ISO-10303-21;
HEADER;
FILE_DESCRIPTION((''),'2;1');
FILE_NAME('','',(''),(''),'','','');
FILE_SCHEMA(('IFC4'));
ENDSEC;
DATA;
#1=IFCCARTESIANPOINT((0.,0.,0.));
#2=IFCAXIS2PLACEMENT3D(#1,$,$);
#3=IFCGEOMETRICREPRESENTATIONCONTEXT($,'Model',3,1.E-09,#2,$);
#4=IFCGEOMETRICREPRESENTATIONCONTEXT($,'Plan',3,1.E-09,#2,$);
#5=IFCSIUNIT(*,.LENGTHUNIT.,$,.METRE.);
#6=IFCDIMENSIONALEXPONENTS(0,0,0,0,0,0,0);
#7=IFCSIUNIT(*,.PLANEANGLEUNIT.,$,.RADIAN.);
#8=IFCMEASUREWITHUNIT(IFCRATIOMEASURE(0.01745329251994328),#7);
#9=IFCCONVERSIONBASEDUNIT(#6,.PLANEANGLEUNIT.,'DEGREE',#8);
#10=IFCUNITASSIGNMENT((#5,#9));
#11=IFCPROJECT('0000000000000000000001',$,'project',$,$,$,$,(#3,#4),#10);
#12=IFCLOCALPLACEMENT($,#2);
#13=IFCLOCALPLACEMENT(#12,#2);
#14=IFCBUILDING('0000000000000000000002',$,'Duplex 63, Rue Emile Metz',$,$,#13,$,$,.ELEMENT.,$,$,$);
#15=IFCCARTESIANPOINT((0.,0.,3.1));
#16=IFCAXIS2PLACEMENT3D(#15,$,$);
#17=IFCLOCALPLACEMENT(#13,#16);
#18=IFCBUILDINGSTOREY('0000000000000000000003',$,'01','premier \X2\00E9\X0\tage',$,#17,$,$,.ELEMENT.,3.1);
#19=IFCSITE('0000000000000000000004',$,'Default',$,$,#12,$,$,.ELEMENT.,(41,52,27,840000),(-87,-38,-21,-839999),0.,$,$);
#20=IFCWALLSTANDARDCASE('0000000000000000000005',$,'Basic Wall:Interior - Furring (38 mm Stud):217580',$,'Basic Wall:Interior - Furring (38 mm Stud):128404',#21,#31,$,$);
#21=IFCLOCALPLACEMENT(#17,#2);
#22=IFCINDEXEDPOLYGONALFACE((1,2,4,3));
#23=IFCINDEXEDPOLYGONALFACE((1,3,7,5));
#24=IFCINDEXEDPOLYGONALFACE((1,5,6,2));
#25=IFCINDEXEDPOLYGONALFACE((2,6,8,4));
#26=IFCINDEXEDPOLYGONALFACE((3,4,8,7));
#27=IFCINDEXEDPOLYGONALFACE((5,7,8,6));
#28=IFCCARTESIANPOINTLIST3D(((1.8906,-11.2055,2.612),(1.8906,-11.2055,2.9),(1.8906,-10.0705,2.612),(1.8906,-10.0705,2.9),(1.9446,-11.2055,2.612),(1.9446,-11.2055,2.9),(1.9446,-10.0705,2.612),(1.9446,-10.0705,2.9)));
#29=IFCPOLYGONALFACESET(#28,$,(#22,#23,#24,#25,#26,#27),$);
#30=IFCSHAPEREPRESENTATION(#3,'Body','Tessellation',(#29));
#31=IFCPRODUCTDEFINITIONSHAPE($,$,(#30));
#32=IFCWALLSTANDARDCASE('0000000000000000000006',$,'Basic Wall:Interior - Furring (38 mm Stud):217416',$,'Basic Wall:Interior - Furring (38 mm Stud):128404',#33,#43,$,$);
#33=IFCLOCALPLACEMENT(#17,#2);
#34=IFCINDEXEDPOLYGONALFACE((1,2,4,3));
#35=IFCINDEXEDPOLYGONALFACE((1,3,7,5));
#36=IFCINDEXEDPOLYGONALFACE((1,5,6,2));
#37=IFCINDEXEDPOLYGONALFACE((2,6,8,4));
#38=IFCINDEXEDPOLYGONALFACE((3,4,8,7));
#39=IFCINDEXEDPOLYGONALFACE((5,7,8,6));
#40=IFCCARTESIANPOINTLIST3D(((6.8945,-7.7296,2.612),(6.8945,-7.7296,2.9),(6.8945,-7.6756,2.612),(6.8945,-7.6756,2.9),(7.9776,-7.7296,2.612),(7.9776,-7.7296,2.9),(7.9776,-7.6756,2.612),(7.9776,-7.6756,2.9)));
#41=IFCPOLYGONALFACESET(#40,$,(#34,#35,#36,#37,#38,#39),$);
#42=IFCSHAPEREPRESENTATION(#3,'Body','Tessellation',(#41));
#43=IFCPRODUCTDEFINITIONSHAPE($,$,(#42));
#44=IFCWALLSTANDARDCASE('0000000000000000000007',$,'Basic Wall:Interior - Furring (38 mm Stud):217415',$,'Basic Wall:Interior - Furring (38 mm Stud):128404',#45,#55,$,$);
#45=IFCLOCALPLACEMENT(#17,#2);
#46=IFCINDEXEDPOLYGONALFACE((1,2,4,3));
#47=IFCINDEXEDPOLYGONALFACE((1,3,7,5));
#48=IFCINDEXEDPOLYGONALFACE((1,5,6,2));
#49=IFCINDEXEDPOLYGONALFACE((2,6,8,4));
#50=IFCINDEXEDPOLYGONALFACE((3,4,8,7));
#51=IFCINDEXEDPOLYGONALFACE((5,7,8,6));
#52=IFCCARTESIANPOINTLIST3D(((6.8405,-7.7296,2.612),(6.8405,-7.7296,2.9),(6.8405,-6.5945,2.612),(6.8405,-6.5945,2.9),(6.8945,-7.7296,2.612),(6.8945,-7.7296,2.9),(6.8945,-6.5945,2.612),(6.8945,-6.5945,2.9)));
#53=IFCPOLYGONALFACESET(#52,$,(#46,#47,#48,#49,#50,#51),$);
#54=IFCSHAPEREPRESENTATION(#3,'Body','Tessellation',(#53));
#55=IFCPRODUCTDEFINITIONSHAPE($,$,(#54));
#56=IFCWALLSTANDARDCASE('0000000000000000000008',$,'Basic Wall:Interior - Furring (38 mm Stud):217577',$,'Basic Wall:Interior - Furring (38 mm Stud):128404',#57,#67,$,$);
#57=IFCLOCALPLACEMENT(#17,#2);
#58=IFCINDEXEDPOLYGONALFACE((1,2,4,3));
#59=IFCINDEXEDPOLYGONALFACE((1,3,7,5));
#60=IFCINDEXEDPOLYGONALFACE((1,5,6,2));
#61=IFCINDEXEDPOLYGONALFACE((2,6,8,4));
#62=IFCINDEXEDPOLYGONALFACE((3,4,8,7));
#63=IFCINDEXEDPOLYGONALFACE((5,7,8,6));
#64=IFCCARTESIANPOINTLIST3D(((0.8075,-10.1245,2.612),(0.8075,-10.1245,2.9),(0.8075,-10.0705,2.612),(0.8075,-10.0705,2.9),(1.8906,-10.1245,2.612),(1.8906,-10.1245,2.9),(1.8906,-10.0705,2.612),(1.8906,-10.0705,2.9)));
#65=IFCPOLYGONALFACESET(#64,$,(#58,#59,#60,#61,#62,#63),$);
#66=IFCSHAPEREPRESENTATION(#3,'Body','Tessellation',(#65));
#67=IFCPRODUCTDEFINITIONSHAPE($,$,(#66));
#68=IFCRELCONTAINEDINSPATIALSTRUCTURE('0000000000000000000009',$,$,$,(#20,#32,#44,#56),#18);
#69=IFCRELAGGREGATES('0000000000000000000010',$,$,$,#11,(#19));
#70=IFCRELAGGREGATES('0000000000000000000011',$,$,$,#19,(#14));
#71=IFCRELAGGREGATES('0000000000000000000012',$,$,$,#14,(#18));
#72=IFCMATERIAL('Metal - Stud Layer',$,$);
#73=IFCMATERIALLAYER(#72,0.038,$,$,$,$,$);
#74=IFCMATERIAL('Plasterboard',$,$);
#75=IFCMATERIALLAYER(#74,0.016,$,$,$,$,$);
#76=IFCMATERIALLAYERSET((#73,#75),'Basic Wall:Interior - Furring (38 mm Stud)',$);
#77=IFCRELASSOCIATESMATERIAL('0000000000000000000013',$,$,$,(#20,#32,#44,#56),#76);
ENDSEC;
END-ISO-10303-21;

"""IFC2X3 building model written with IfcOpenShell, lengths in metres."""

from ifc_helpers import new_model, entity, si_unit, converted_unit, frame, frame_2d, origin, place, context, project, spatial, rectangle, extrude, material, layer, layer_set, layer_usage, element, save


model = new_model("IFC2X3")

# Units and contexts
model_context = context("Model", 3, precision=1e-09, world=origin())
plan_context = context("Plan", 3, precision=1e-09, world=origin())
ifc_project = project(units=[si_unit("LENGTHUNIT", "METRE"), converted_unit("PLANEANGLEUNIT", "DEGREE", entity("IfcRatioMeasure", 0.01745329251994328), si_unit("PLANEANGLEUNIT", "RADIAN"), dimensions=[0, 0, 0, 0, 0, 0, 0])], contexts=[model_context, plan_context])

# Site, building, storey
site_placement = place(None, origin())
site = spatial("IfcSite", under=ifc_project, at=site_placement, Name="Default", CompositionType="ELEMENT", RefLatitude=(41, 52, 27, 840000), RefLongitude=(-87, -38, -21, -839999), RefElevation=0.0)
building_placement = place(site_placement, origin())
building = spatial("IfcBuilding", under=site, at=building_placement, Name="Duplex 63, Rue Emile Metz", CompositionType="ELEMENT")
storey_placement = place(building_placement, frame((0.0, 0.0, 3.1)))
storey = spatial("IfcBuildingStorey", under=building, at=storey_placement, Name="01", Description="premier étage", CompositionType="ELEMENT", Elevation=3.1)

# Shared definitions
ifc_material_1 = material(Name="Plasterboard")
ifc_material_2 = material(Name="Metal - Stud Layer")

# Walls
ifc_layer_1 = layer(ifc_material_2, 0.038)
ifc_layer_2 = layer(ifc_material_1, 0.016)
ifc_layer_set_1 = layer_set([ifc_layer_1, ifc_layer_2], Name="Basic Wall:Interior - Furring (38 mm Stud)")
ifc_layer_usage_1 = layer_usage(ifc_layer_set_1, "AXIS2", "NEGATIVE", 0.027)
wall_1_placement = place(storey_placement, frame((1.9176, -10.0705, 2.612), z_axis=(0.0, 0.0, 1.0), x_axis=(0.0, -1.0, 0.0)))
element("IfcWallStandardCase", 1, at=wall_1_placement, inside=storey, material=ifc_layer_usage_1, Name="Basic Wall:Interior - Furring (38 mm Stud):217580", ObjectType="Basic Wall:Interior - Furring (38 mm Stud):128404", context=model_context, shape_type="SweptSolid", body=[
    extrude(rectangle(XDim=1.1351, YDim=0.054, at=frame_2d((0.5675, 0.0), x_axis=(-1.0, 0.0))), origin(), (0.0, 0.0, 1.0), 0.288),
])
wall_2_placement = place(storey_placement, frame((7.9776, -7.7026, 2.612), z_axis=(0.0, 0.0, 1.0), x_axis=(-1.0, 0.0, 0.0)))
element("IfcWallStandardCase", 2, at=wall_2_placement, inside=storey, material=ifc_layer_usage_1, Name="Basic Wall:Interior - Furring (38 mm Stud):217416", ObjectType="Basic Wall:Interior - Furring (38 mm Stud):128404", context=model_context, shape_type="SweptSolid", body=[
    extrude(rectangle(XDim=1.0831, YDim=0.054, at=frame_2d((0.5416, 0.0), x_axis=(-1.0, 0.0))), origin(), (0.0, 0.0, 1.0), 0.288),
])
wall_3_placement = place(storey_placement, frame((6.8675, -7.7296, 2.612), z_axis=(0.0, 0.0, 1.0), x_axis=(0.0, 1.0, 0.0)))
element("IfcWallStandardCase", 3, at=wall_3_placement, inside=storey, material=ifc_layer_usage_1, Name="Basic Wall:Interior - Furring (38 mm Stud):217415", ObjectType="Basic Wall:Interior - Furring (38 mm Stud):128404", context=model_context, shape_type="SweptSolid", body=[
    extrude(rectangle(XDim=1.1351, YDim=0.054, at=frame_2d((0.5675, 0.0), x_axis=(-1.0, 0.0))), origin(), (0.0, 0.0, 1.0), 0.288),
])
wall_4_placement = place(storey_placement, frame((0.8075, -10.0975, 2.612)))
element("IfcWallStandardCase", 4, at=wall_4_placement, inside=storey, material=ifc_layer_usage_1, Name="Basic Wall:Interior - Furring (38 mm Stud):217577", ObjectType="Basic Wall:Interior - Furring (38 mm Stud):128404", context=model_context, shape_type="SweptSolid", body=[
    extrude(rectangle(XDim=1.0831, YDim=0.054, at=frame_2d((0.5415, 0.0), x_axis=(-1.0, 0.0))), origin(), (0.0, 0.0, 1.0), 0.288),
])

save(model, "model.ifc")
